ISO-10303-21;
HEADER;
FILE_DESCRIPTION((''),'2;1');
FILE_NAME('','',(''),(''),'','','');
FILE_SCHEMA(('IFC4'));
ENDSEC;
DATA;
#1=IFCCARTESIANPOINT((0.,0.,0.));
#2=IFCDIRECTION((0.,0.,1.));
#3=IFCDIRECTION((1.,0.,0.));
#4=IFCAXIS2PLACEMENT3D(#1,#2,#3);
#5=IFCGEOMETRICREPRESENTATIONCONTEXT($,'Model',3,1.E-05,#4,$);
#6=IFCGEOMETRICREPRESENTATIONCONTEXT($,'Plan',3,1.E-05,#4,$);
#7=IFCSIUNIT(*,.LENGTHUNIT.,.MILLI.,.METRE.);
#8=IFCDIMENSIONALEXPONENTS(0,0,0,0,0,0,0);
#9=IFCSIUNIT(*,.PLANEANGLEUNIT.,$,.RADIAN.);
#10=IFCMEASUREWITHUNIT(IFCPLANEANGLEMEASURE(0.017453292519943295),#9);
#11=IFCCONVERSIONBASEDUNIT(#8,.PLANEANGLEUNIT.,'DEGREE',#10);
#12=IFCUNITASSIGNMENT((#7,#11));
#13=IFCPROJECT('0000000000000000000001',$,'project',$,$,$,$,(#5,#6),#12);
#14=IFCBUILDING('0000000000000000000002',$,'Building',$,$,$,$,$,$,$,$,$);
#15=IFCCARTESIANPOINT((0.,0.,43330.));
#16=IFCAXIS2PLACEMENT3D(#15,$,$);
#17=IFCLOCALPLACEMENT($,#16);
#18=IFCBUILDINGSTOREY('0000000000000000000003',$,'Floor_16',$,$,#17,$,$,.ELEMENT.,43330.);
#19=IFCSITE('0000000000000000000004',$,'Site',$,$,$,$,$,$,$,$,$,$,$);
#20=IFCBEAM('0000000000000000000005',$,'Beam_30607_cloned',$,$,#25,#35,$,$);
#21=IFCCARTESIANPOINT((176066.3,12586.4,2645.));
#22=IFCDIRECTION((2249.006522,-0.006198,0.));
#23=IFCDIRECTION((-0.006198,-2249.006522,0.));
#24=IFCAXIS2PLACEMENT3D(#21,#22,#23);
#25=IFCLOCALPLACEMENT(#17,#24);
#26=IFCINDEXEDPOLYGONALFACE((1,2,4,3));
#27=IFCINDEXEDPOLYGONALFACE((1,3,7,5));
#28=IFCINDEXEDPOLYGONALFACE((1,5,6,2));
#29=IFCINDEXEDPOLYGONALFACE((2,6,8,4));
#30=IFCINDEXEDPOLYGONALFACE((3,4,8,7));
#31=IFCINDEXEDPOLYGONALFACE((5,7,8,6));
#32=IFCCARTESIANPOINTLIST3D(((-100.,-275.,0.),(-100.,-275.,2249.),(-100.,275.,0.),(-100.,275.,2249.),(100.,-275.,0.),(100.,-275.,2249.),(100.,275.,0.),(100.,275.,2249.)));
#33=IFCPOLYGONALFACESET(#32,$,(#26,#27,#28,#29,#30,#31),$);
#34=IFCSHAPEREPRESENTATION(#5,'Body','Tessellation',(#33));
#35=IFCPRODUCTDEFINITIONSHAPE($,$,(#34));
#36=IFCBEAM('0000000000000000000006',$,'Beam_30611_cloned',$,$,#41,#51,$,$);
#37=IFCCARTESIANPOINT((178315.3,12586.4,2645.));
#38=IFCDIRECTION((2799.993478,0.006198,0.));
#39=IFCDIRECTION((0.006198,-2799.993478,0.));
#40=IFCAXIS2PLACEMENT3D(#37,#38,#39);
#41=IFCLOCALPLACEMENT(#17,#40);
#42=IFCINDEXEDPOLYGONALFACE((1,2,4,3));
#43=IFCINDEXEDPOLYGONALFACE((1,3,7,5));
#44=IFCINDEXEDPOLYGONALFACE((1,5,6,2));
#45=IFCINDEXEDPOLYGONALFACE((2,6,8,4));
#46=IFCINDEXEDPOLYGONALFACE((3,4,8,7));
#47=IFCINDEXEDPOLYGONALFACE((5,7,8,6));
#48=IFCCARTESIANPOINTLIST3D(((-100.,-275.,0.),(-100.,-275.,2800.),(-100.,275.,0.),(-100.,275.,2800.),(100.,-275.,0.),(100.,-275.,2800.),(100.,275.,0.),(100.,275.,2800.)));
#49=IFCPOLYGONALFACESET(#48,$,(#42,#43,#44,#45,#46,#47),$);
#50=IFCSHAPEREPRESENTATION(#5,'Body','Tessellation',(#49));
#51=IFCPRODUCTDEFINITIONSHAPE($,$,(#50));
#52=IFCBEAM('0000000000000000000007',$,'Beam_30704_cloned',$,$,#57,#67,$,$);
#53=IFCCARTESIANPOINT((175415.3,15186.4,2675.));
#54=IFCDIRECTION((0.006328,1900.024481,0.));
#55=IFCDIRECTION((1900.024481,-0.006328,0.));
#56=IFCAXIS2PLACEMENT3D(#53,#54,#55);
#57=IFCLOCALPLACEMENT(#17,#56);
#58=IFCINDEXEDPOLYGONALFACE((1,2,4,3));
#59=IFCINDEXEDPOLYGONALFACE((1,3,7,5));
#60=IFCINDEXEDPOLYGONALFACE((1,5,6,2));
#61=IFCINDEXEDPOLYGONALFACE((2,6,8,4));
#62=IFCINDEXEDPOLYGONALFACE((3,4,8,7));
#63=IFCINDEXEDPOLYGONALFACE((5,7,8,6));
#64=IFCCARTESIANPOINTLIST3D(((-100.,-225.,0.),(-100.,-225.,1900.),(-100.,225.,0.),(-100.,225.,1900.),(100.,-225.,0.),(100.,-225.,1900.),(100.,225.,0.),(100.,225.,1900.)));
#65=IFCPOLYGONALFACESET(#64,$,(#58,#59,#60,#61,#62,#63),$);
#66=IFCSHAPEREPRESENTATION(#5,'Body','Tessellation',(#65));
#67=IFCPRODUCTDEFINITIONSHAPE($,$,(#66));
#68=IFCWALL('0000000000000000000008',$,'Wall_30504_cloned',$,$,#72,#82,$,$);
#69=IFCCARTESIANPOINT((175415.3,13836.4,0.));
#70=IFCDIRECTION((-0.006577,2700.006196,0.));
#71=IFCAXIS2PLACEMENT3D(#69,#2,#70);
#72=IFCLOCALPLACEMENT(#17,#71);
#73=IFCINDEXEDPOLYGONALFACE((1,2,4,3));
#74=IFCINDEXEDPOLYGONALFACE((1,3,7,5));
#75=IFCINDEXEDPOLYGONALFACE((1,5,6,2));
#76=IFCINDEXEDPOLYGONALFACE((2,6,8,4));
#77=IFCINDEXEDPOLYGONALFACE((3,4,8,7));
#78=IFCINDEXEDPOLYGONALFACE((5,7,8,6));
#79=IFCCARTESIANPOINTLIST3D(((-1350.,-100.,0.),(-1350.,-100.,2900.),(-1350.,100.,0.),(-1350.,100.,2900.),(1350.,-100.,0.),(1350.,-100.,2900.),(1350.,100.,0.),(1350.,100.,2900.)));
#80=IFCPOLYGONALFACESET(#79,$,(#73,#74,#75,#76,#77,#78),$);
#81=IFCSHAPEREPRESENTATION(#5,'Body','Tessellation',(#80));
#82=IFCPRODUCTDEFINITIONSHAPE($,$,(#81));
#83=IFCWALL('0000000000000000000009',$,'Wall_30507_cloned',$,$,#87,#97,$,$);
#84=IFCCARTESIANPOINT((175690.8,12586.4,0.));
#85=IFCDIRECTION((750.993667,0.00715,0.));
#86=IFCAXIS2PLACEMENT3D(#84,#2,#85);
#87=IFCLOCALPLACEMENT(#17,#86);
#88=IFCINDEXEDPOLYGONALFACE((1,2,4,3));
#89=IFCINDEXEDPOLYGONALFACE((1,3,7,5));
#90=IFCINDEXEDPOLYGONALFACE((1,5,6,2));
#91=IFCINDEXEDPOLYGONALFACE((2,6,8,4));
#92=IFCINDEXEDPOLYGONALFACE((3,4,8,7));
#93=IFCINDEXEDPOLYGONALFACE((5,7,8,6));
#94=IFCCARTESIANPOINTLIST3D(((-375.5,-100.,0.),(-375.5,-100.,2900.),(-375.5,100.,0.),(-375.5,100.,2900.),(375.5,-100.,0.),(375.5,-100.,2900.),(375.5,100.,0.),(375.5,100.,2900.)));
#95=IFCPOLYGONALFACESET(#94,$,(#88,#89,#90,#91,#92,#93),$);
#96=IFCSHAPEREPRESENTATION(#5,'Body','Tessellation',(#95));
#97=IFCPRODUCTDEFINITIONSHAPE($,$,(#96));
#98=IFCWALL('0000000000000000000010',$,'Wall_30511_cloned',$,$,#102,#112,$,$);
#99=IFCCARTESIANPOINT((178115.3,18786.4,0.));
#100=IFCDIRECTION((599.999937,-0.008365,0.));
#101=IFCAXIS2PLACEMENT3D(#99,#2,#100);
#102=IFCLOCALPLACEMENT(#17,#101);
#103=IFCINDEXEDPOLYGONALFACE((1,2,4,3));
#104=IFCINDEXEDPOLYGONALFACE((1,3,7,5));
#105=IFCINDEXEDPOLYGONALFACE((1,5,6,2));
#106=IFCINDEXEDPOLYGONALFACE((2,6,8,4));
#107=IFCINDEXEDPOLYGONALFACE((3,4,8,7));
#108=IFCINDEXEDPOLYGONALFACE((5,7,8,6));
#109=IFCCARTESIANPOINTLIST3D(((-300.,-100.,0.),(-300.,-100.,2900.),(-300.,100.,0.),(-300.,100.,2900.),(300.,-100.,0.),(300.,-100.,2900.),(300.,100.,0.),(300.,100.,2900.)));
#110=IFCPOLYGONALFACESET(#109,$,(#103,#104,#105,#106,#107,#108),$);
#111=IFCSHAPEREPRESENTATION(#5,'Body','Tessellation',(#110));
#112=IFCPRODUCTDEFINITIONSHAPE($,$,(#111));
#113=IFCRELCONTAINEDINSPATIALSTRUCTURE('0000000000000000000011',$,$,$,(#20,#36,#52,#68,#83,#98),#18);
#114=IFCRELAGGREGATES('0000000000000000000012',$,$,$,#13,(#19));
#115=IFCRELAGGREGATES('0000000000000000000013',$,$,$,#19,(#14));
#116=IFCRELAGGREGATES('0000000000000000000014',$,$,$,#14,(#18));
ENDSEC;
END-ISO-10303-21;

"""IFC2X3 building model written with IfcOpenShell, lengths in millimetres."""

from ifc_helpers import new_model, entity, si_unit, converted_unit, frame, origin_with_axes, origin_2d, place, context, project, spatial, rectangle, extrude, source, transform, mapped, element, save


model = new_model("IFC2X3")

# Units and contexts
model_context = context("Model", 3, precision=1e-05, world=origin_with_axes())
plan_context = context("Plan", 3, precision=1e-05, world=origin_with_axes())
ifc_project = project(units=[si_unit("LENGTHUNIT", "METRE", prefix="MILLI"), converted_unit("PLANEANGLEUNIT", "DEGREE", entity("IfcPlaneAngleMeasure", 0.017453292519943295), si_unit("PLANEANGLEUNIT", "RADIAN"), dimensions=[0, 0, 0, 0, 0, 0, 0])], contexts=[model_context, plan_context])

# Site, building, storey
site = spatial("IfcSite", under=ifc_project, Name="Site")
building = spatial("IfcBuilding", under=site, Name="Building")
storey_placement = place(None, frame((0.0, 0.0, 43330.0)))
storey = spatial("IfcBuildingStorey", under=building, at=storey_placement, Name="Floor_16", CompositionType="ELEMENT", Elevation=43330.0)

# Beams
shared_shape_1 = source(origin_with_axes(), model_context, "Body", "SweptSolid", [
    extrude(rectangle(XDim=200.0, YDim=550.0, at=origin_2d()), origin_with_axes(), (0.0, 0.0, 1.0), 2249.0),
])
beam_1_placement = place(storey_placement, frame((176066.3, 12586.4, 2645.0), z_axis=(2249.006522, -0.006198, 0.0), x_axis=(-0.006198, -2249.006522, 0.0)))
element("IfcBeam", 1, at=beam_1_placement, inside=storey, Name="Beam_30607_cloned", context=model_context, shape_type="MappedRepresentation", body=[
    mapped(shared_shape_1, transform((0.0, 0.0, 0.0), x_axis=(1.0, 0.0, 0.0), y_axis=(0.0, 1.0, 0.0), z_axis=(0.0, 0.0, 1.0), scale=1.0)),
])
shared_shape_2 = source(origin_with_axes(), model_context, "Body", "SweptSolid", [
    extrude(rectangle(XDim=200.0, YDim=550.0, at=origin_2d()), origin_with_axes(), (0.0, 0.0, 1.0), 2800.0),
])
beam_2_placement = place(storey_placement, frame((178315.3, 12586.4, 2645.0), z_axis=(2799.993478, 0.006198, 0.0), x_axis=(0.006198, -2799.993478, 0.0)))
element("IfcBeam", 2, at=beam_2_placement, inside=storey, Name="Beam_30611_cloned", context=model_context, shape_type="MappedRepresentation", body=[
    mapped(shared_shape_2, transform((0.0, 0.0, 0.0), x_axis=(1.0, 0.0, 0.0), y_axis=(0.0, 1.0, 0.0), z_axis=(0.0, 0.0, 1.0), scale=1.0)),
])
shared_shape_3 = source(origin_with_axes(), model_context, "Body", "SweptSolid", [
    extrude(rectangle(XDim=200.0, YDim=450.0, at=origin_2d()), origin_with_axes(), (0.0, 0.0, 1.0), 1900.0),
])
beam_3_placement = place(storey_placement, frame((175415.3, 15186.4, 2675.0), z_axis=(0.006328, 1900.024481, 0.0), x_axis=(1900.024481, -0.006328, 0.0)))
element("IfcBeam", 3, at=beam_3_placement, inside=storey, Name="Beam_30704_cloned", context=model_context, shape_type="MappedRepresentation", body=[
    mapped(shared_shape_3, transform((0.0, 0.0, 0.0), x_axis=(1.0, 0.0, 0.0), y_axis=(0.0, 1.0, 0.0), z_axis=(0.0, 0.0, 1.0), scale=1.0)),
])

# Walls
shared_shape_4 = source(origin_with_axes(), model_context, "Body", "SweptSolid", [
    extrude(rectangle(XDim=2700.0, YDim=200.0, at=origin_2d()), origin_with_axes(), (0.0, 0.0, 1.0), 2900.0),
])
wall_1_placement = place(storey_placement, frame((175415.3, 13836.4, 0.0), z_axis=(0.0, 0.0, 1.0), x_axis=(-0.006577, 2700.006196, 0.0)))
element("IfcWall", 4, at=wall_1_placement, inside=storey, Name="Wall_30504_cloned", context=model_context, shape_type="MappedRepresentation", body=[
    mapped(shared_shape_4, transform((0.0, 0.0, 0.0), x_axis=(1.0, 0.0, 0.0), y_axis=(0.0, 1.0, 0.0), z_axis=(0.0, 0.0, 1.0), scale=1.0)),
])
shared_shape_5 = source(origin_with_axes(), model_context, "Body", "SweptSolid", [
    extrude(rectangle(XDim=751.0, YDim=200.0, at=origin_2d()), origin_with_axes(), (0.0, 0.0, 1.0), 2900.0),
])
wall_2_placement = place(storey_placement, frame((175690.8, 12586.4, 0.0), z_axis=(0.0, 0.0, 1.0), x_axis=(750.993667, 0.00715, 0.0)))
element("IfcWall", 5, at=wall_2_placement, inside=storey, Name="Wall_30507_cloned", context=model_context, shape_type="MappedRepresentation", body=[
    mapped(shared_shape_5, transform((0.0, 0.0, 0.0), x_axis=(1.0, 0.0, 0.0), y_axis=(0.0, 1.0, 0.0), z_axis=(0.0, 0.0, 1.0), scale=1.0)),
])
shared_shape_6 = source(origin_with_axes(), model_context, "Body", "SweptSolid", [
    extrude(rectangle(XDim=600.0, YDim=200.0, at=origin_2d()), origin_with_axes(), (0.0, 0.0, 1.0), 2900.0),
])
wall_3_placement = place(storey_placement, frame((178115.3, 18786.4, 0.0), z_axis=(0.0, 0.0, 1.0), x_axis=(599.999937, -0.008365, 0.0)))
element("IfcWall", 6, at=wall_3_placement, inside=storey, Name="Wall_30511_cloned", context=model_context, shape_type="MappedRepresentation", body=[
    mapped(shared_shape_6, transform((0.0, 0.0, 0.0), x_axis=(1.0, 0.0, 0.0), y_axis=(0.0, 1.0, 0.0), z_axis=(0.0, 0.0, 1.0), scale=1.0)),
])

save(model, "model.ifc")
